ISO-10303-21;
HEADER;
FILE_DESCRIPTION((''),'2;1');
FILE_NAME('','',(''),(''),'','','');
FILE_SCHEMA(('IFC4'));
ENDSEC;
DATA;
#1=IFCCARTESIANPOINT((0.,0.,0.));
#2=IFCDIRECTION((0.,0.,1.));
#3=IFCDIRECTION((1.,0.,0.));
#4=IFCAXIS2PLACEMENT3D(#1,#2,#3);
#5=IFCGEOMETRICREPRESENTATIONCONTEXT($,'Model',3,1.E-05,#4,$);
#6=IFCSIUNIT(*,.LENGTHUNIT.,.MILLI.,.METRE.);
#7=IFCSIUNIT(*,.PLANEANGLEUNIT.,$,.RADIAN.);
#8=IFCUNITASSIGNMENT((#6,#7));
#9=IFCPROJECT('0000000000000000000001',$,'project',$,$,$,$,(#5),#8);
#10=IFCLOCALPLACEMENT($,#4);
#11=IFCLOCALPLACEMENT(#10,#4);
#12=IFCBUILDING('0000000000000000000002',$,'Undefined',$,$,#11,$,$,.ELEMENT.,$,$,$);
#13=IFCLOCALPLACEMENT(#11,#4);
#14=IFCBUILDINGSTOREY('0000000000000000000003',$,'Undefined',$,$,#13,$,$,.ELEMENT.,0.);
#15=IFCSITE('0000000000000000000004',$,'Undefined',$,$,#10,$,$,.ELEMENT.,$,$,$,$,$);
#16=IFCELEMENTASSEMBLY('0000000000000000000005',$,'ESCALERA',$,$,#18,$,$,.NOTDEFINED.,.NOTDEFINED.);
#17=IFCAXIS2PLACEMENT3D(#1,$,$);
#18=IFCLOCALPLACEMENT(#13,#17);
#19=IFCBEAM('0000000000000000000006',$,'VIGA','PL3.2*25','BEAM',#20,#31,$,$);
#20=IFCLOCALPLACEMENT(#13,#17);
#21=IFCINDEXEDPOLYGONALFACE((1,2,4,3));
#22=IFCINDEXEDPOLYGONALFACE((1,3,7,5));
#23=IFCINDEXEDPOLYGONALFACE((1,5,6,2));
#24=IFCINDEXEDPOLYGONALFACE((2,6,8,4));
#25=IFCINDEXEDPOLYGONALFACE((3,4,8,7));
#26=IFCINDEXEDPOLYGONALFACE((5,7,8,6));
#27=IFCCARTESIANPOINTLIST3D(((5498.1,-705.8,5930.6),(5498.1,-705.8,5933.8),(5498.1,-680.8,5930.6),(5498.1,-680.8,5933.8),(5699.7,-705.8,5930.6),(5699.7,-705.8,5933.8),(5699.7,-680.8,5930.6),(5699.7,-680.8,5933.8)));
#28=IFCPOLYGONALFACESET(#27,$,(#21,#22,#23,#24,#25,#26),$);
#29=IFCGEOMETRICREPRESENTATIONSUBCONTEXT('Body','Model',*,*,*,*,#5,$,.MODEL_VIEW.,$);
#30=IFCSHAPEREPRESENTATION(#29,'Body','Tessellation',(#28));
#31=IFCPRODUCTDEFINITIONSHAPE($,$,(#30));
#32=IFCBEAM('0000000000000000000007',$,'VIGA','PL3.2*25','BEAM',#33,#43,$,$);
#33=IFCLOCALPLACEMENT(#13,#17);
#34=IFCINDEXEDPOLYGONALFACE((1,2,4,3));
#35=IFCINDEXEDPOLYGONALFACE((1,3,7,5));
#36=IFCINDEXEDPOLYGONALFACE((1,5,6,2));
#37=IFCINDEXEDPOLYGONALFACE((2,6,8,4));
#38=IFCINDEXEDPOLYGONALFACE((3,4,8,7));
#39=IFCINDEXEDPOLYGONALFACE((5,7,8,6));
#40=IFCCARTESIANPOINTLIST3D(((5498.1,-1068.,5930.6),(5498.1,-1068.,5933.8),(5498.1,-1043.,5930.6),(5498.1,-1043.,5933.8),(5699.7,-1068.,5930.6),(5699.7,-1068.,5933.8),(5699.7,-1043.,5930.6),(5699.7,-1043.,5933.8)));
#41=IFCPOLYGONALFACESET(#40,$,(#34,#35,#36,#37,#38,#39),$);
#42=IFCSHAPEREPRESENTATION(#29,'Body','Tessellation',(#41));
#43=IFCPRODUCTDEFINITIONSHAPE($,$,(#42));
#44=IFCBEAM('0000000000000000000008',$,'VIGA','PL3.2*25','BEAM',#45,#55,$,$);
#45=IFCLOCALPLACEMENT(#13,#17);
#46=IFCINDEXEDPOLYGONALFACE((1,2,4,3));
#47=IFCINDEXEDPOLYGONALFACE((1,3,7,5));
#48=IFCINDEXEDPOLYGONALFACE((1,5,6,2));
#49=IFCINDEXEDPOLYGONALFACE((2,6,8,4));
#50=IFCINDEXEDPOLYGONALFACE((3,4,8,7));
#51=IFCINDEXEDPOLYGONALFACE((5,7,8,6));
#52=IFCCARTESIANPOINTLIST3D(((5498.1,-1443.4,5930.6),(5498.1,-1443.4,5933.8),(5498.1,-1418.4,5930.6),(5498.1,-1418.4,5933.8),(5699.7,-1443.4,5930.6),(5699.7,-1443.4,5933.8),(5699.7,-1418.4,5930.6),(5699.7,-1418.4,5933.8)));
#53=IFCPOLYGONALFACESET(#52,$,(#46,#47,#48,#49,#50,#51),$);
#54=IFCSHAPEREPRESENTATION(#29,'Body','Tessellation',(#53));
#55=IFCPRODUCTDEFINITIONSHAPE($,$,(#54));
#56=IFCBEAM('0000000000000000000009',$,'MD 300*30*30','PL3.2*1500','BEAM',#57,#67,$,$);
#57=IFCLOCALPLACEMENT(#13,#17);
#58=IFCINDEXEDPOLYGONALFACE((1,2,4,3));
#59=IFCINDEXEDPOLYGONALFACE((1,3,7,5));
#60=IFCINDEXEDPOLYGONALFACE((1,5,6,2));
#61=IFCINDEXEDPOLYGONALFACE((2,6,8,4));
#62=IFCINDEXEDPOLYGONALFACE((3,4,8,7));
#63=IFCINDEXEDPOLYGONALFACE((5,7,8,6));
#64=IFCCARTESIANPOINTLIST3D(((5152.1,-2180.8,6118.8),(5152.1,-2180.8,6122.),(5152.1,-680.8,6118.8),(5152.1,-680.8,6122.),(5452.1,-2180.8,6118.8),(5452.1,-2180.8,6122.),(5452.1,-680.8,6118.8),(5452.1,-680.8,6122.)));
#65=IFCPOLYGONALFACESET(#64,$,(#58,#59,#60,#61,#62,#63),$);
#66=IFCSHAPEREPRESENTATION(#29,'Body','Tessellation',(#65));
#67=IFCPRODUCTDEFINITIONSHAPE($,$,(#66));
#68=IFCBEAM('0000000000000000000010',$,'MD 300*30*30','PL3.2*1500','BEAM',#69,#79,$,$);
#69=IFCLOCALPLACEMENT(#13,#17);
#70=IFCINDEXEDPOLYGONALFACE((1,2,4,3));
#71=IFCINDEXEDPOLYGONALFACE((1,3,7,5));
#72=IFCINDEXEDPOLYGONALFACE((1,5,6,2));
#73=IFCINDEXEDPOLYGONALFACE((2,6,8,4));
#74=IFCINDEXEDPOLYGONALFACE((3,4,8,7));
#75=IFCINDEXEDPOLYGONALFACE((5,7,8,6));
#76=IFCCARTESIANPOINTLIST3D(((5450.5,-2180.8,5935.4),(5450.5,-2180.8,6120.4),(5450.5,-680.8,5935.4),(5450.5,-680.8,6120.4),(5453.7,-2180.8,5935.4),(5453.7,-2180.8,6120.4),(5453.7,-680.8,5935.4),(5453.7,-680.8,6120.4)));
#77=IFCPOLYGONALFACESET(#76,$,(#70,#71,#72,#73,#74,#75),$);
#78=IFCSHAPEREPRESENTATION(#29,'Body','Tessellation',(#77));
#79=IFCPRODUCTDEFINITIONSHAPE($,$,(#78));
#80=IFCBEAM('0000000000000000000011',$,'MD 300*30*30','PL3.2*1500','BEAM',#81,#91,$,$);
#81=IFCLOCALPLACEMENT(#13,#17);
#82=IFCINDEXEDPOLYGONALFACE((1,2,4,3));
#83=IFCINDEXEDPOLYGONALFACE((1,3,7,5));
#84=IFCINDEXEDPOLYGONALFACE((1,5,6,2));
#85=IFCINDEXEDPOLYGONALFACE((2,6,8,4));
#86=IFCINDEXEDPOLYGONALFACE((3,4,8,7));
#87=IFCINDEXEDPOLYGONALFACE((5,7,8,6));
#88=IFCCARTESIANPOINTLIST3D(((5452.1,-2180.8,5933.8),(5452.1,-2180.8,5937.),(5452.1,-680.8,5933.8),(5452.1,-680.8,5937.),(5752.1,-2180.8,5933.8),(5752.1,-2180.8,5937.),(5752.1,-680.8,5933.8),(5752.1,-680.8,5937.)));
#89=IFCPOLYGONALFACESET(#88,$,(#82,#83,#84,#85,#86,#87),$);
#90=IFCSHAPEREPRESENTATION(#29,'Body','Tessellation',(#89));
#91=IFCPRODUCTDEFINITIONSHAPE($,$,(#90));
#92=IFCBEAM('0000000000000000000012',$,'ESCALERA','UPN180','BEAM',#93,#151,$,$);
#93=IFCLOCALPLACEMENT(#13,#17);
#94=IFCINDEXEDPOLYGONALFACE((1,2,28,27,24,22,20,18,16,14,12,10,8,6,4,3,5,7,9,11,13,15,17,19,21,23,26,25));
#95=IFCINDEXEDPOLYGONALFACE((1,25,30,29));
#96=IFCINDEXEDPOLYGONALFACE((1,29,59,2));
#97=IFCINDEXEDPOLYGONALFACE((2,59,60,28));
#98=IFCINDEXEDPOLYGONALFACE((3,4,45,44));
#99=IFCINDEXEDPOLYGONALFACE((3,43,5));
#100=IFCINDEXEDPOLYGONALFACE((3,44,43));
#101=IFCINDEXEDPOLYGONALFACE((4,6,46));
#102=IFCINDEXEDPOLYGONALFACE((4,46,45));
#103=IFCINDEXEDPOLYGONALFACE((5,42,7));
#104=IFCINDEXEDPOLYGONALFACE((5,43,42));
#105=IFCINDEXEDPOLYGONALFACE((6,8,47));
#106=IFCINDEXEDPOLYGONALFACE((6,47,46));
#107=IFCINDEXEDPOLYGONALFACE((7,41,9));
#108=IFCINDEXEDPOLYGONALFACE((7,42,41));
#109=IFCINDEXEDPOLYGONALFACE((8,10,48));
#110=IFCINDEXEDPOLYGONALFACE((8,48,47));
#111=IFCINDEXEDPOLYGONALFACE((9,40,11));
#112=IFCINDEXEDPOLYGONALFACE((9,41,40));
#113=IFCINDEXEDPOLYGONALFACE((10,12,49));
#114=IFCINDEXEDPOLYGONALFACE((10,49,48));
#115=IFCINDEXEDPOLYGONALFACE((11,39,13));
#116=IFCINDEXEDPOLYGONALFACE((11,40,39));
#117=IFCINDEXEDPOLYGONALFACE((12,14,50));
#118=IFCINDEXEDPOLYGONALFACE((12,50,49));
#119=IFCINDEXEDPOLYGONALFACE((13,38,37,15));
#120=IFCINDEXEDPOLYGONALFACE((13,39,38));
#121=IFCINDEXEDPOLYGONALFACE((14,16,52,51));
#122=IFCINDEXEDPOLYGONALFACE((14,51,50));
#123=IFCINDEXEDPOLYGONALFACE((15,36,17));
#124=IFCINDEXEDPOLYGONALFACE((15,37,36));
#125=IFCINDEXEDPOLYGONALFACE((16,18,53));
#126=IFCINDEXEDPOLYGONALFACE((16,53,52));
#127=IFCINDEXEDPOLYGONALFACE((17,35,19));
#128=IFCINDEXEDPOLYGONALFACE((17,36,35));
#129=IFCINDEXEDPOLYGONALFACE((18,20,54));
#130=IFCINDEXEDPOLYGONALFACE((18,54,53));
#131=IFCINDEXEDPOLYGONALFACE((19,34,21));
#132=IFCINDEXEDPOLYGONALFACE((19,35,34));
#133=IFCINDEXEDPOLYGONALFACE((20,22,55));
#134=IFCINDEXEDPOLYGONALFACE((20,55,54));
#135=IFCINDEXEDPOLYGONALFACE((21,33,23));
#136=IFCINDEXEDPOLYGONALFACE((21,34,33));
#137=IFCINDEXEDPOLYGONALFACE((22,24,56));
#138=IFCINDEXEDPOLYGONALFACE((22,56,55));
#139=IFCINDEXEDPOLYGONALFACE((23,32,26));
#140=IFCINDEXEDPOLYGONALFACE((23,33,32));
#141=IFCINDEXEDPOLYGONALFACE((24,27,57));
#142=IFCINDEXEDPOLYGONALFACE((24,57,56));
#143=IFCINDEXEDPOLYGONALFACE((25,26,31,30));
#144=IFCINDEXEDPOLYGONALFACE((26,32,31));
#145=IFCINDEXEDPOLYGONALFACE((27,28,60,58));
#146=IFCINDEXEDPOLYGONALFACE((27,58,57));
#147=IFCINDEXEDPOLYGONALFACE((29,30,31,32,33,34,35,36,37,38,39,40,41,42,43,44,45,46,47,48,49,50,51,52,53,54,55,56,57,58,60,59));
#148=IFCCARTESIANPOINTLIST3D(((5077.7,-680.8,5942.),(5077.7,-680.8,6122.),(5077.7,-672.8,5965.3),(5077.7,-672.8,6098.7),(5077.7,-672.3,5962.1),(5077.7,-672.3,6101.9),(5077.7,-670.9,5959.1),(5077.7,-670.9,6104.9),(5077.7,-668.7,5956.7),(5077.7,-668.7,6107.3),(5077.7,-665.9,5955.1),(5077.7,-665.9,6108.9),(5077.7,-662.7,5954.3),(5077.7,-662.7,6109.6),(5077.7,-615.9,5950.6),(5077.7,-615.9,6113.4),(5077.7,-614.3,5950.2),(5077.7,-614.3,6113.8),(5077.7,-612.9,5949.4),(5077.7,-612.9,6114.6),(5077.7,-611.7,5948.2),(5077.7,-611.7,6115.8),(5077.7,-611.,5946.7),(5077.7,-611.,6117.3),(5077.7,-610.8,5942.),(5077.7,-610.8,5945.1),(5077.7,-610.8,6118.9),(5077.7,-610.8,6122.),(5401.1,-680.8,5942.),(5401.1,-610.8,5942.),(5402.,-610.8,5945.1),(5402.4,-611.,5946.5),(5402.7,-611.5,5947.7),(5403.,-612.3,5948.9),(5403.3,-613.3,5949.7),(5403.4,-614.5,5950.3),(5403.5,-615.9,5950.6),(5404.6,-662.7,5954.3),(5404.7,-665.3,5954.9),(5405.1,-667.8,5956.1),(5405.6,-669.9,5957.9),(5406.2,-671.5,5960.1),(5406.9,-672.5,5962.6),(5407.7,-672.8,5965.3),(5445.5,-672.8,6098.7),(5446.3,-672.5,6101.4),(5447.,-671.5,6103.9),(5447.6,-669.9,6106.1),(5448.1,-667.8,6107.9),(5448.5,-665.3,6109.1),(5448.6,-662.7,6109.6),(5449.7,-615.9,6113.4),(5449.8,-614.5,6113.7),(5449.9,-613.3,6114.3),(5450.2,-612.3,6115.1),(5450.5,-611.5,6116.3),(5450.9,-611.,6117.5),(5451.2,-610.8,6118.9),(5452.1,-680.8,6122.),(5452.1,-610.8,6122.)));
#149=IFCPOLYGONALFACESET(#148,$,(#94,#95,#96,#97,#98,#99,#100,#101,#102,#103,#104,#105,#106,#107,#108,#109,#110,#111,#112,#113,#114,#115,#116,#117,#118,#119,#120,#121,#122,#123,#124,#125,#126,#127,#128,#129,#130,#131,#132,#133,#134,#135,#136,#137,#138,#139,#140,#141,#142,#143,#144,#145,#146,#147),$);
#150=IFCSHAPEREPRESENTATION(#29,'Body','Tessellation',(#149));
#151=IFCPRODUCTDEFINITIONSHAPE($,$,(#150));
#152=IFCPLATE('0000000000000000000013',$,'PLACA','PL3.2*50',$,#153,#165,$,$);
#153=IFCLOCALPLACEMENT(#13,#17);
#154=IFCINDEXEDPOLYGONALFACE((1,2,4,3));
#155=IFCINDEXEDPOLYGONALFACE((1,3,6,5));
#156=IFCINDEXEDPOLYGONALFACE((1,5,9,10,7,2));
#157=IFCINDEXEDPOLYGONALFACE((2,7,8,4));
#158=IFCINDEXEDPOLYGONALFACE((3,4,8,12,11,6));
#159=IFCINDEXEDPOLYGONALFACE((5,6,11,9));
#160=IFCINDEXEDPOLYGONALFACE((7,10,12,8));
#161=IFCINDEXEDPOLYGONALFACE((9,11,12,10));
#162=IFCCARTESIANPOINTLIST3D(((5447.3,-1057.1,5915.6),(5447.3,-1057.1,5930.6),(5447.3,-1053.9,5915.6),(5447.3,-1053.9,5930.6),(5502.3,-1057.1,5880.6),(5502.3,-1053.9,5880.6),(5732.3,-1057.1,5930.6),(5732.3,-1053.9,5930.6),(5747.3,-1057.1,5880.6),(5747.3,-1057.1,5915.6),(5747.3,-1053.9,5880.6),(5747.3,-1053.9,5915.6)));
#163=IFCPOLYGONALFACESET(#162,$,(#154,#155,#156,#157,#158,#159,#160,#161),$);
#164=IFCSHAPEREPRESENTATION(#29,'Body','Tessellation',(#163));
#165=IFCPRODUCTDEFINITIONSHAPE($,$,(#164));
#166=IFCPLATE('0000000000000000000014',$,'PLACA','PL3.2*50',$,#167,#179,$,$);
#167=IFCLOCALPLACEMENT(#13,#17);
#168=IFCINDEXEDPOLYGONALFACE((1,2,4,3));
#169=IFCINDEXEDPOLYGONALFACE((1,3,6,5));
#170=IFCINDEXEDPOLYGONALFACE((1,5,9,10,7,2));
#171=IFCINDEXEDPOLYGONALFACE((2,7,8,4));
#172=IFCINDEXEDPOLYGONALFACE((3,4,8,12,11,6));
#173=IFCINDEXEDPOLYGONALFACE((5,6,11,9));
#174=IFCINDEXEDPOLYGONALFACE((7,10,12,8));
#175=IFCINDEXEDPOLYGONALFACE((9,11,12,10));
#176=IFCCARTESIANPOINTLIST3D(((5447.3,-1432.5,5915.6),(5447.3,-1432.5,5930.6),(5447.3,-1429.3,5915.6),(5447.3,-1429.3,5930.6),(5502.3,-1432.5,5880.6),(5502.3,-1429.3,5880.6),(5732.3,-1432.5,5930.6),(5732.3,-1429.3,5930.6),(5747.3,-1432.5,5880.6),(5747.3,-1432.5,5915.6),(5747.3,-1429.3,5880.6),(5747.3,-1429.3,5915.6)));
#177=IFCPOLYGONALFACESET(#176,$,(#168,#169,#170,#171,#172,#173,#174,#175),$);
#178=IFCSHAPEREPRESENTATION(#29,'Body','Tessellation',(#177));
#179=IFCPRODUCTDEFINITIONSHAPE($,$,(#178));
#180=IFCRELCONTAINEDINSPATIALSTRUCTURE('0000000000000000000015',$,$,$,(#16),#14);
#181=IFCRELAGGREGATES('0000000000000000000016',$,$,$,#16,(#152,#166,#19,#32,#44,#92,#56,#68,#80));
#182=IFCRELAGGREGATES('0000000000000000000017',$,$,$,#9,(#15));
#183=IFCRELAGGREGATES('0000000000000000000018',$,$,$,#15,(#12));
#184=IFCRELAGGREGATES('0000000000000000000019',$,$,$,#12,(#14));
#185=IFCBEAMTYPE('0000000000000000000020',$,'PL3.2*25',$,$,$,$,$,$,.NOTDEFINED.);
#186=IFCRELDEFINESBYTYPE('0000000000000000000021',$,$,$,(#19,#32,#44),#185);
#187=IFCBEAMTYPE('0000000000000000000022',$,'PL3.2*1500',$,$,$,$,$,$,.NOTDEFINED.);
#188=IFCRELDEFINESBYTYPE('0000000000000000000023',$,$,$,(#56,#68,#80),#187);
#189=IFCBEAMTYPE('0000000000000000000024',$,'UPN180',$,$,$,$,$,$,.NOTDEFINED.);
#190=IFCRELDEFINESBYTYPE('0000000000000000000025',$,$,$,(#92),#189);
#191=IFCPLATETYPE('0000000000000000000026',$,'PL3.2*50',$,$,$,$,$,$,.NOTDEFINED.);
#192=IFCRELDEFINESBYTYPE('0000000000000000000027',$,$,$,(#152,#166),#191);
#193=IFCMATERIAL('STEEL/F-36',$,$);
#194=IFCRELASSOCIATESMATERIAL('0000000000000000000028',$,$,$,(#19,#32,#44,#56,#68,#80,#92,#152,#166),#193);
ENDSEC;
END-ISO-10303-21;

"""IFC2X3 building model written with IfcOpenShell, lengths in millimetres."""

from ifc_helpers import new_model, si_unit, frame, origin_with_axes, origin_2d_with_axis, place, context, subcontext, project, spatial, polyline, rectangle, u_section, outline, extrude, clip, halfspace, material, type_object, element, aggregate, save


model = new_model("IFC2X3")

# Units and contexts
model_context = context("Model", 3, precision=1e-05, world=origin_with_axes())
body_context = subcontext(model_context, "Body", "Model", "MODEL_VIEW")
ifc_project = project(units=[si_unit("LENGTHUNIT", "METRE", prefix="MILLI"), si_unit("PLANEANGLEUNIT", "RADIAN")], contexts=[model_context])

# Site, building, storey
site_placement = place(None, origin_with_axes())
site = spatial("IfcSite", under=ifc_project, at=site_placement, Name="Undefined", CompositionType="ELEMENT")
building_placement = place(site_placement, origin_with_axes())
building = spatial("IfcBuilding", under=site, at=building_placement, Name="Undefined", CompositionType="ELEMENT")
storey_placement = place(building_placement, origin_with_axes())
storey = spatial("IfcBuildingStorey", under=building, at=storey_placement, Name="Undefined", CompositionType="ELEMENT", Elevation=0.0)

# Element assembly
assembly_1_placement = place(storey_placement, origin_with_axes())
assembly_1 = element("IfcElementAssembly", 1, at=assembly_1_placement, inside=storey, Name="ESCALERA", AssemblyPlace="NOTDEFINED", PredefinedType="NOTDEFINED")
ifc_material_1 = material(Name="STEEL/F-36")

# Beams
beam_type_1 = type_object("IfcBeamType", Name="PL3.2*25", PredefinedType="NOTDEFINED")
beam_1_placement = place(assembly_1_placement, frame((5699.7, -693.3, 5932.2), z_axis=(0.0, 1.0, 0.0), x_axis=(-1.0, 0.0, 0.000012)))
beam_1 = element("IfcBeam", 2, at=beam_1_placement, type_object=beam_type_1, material=ifc_material_1, Name="VIGA", Description="PL3.2*25", ObjectType="BEAM", context=body_context, shape_type="SweptSolid", body=[
    extrude(rectangle(XDim=3.2, YDim=25.0, at=origin_2d_with_axis()), frame((201.6, 0.0, 0.0), z_axis=(-1.0, 0.0, 0.0), x_axis=(0.0, -1.0, 0.0)), (0.0, 0.0, 1.0), 201.6),
])
beam_2_placement = place(assembly_1_placement, frame((5699.7, -1055.5, 5932.2), z_axis=(0.0, 1.0, 0.0), x_axis=(-1.0, 0.0, 0.000012)))
beam_2 = element("IfcBeam", 3, at=beam_2_placement, type_object=beam_type_1, material=ifc_material_1, Name="VIGA", Description="PL3.2*25", ObjectType="BEAM", context=body_context, shape_type="SweptSolid", body=[
    extrude(rectangle(XDim=3.2, YDim=25.0, at=origin_2d_with_axis()), frame((201.6, 0.0, 0.0), z_axis=(-1.0, 0.0, 0.0), x_axis=(0.0, -1.0, 0.0)), (0.0, 0.0, 1.0), 201.6),
])
beam_3_placement = place(assembly_1_placement, frame((5699.7, -1430.9, 5932.2), z_axis=(0.0, 1.0, 0.0), x_axis=(-1.0, 0.0, 0.000012)))
beam_3 = element("IfcBeam", 4, at=beam_3_placement, type_object=beam_type_1, material=ifc_material_1, Name="VIGA", Description="PL3.2*25", ObjectType="BEAM", context=body_context, shape_type="SweptSolid", body=[
    extrude(rectangle(XDim=3.2, YDim=25.0, at=origin_2d_with_axis()), frame((201.6, 0.0, 0.0), z_axis=(-1.0, 0.0, 0.0), x_axis=(0.0, -1.0, 0.0)), (0.0, 0.0, 1.0), 201.6),
])
beam_type_2 = type_object("IfcBeamType", Name="PL3.2*1500", PredefinedType="NOTDEFINED")
beam_4_placement = place(assembly_1_placement, frame((5452.1, -1430.8, 6120.4), z_axis=(0.0, -1.0, 0.0), x_axis=(-1.0, 0.0, 0.0)))
beam_4 = element("IfcBeam", 5, at=beam_4_placement, type_object=beam_type_2, material=ifc_material_1, Name="MD 300*30*30", Description="PL3.2*1500", ObjectType="BEAM", context=body_context, shape_type="SweptSolid", body=[
    extrude(rectangle(XDim=3.2, YDim=1500.0, at=origin_2d_with_axis()), frame((300.0, 0.0, 0.0), z_axis=(-1.0, 0.0, 0.0), x_axis=(0.0, -1.0, 0.0)), (0.0, 0.0, 1.0), 300.0),
])
beam_5_placement = place(assembly_1_placement, frame((5452.1, -1430.8, 5935.4), z_axis=(0.0, -1.0, 0.0), x_axis=(0.0, 0.0, 1.0)))
beam_5 = element("IfcBeam", 6, at=beam_5_placement, type_object=beam_type_2, material=ifc_material_1, Name="MD 300*30*30", Description="PL3.2*1500", ObjectType="BEAM", context=body_context, shape_type="SweptSolid", body=[
    extrude(rectangle(XDim=3.2, YDim=1500.0, at=origin_2d_with_axis()), frame((185.0, 0.0, 0.0), z_axis=(-1.0, 0.0, 0.0), x_axis=(0.0, -1.0, 0.0)), (0.0, 0.0, 1.0), 185.0),
])
beam_6_placement = place(assembly_1_placement, frame((5752.1, -1430.8, 5935.4), z_axis=(0.0, -1.0, 0.0), x_axis=(-1.0, 0.0, 0.0)))
beam_6 = element("IfcBeam", 7, at=beam_6_placement, type_object=beam_type_2, material=ifc_material_1, Name="MD 300*30*30", Description="PL3.2*1500", ObjectType="BEAM", context=body_context, shape_type="SweptSolid", body=[
    extrude(rectangle(XDim=3.2, YDim=1500.0, at=origin_2d_with_axis()), frame((300.0, 0.0, 0.0), z_axis=(-1.0, 0.0, 0.0), x_axis=(0.0, -1.0, 0.0)), (0.0, 0.0, 1.0), 300.0),
])
beam_type_3 = type_object("IfcBeamType", Name="UPN180", PredefinedType="NOTDEFINED")
beam_7_placement = place(assembly_1_placement, frame((5452.1, -645.8, 6032.0), z_axis=(0.0, 0.0, 1.0), x_axis=(-1.0, 0.0, 0.0)))
beam_7 = element("IfcBeam", 8, at=beam_7_placement, type_object=beam_type_3, material=ifc_material_1, Name="ESCALERA", Description="UPN180", ObjectType="BEAM", context=body_context, shape_type="Clipping", body=[
    clip(extrude(u_section(Depth=180.0, FlangeWidth=70.0, WebThickness=8.0, FlangeThickness=11.0, FilletRadius=11.0, EdgeRadius=5.5, FlangeSlope=0.07983, at=origin_2d_with_axis()), frame((374.4, 0.0, 0.0), z_axis=(-1.0, 0.0, 0.0), x_axis=(0.0, -1.0, 0.0)), (0.0, 0.0, 1.0), 374.6), halfspace(frame((0.0, 0.0, 90.0), z_axis=(-0.962074, 0.0, -0.27279), x_axis=(0.0, -1.0, 0.0)), False)),
])

# Plates
plate_type = type_object("IfcPlateType", Name="PL3.2*50", PredefinedType="NOTDEFINED")
plate_1_placement = place(assembly_1_placement, frame((5447.3, -1055.5, 5930.6), z_axis=(0.0, -1.0, 0.0), x_axis=(0.0, 0.0, -1.0)))
plate_1 = element("IfcPlate", 9, at=plate_1_placement, type_object=plate_type, material=ifc_material_1, Name="PLACA", Description="PL3.2*50", context=body_context, shape_type="SweptSolid", body=[
    extrude(outline(polyline([(0.0, 0.0), (15.0, 0.0), (50.0, 55.0), (50.0, 300.0), (50.0, 300.0), (15.0, 300.0), (0.0, 285.0), (0.0, 0.0)])), frame((0.0, 0.0, -1.6), z_axis=(0.0, 0.0, 1.0), x_axis=(1.0, 0.0, 0.0)), (0.0, 0.0, 1.0), 3.2),
])
plate_2_placement = place(assembly_1_placement, frame((5447.3, -1430.9, 5930.6), z_axis=(0.0, -1.0, 0.0), x_axis=(0.0, 0.0, -1.0)))
plate_2 = element("IfcPlate", 10, at=plate_2_placement, type_object=plate_type, material=ifc_material_1, Name="PLACA", Description="PL3.2*50", context=body_context, shape_type="SweptSolid", body=[
    extrude(outline(polyline([(0.0, 0.0), (15.0, 0.0), (50.0, 55.0), (50.0, 300.0), (50.0, 300.0), (15.0, 300.0), (0.0, 285.0), (0.0, 0.0)])), frame((0.0, 0.0, -1.6), z_axis=(0.0, 0.0, 1.0), x_axis=(1.0, 0.0, 0.0)), (0.0, 0.0, 1.0), 3.2),
])
aggregate(assembly_1, [plate_1, plate_2, beam_1, beam_2, beam_3, beam_7, beam_4, beam_5, beam_6])

save(model, "model.ifc")
